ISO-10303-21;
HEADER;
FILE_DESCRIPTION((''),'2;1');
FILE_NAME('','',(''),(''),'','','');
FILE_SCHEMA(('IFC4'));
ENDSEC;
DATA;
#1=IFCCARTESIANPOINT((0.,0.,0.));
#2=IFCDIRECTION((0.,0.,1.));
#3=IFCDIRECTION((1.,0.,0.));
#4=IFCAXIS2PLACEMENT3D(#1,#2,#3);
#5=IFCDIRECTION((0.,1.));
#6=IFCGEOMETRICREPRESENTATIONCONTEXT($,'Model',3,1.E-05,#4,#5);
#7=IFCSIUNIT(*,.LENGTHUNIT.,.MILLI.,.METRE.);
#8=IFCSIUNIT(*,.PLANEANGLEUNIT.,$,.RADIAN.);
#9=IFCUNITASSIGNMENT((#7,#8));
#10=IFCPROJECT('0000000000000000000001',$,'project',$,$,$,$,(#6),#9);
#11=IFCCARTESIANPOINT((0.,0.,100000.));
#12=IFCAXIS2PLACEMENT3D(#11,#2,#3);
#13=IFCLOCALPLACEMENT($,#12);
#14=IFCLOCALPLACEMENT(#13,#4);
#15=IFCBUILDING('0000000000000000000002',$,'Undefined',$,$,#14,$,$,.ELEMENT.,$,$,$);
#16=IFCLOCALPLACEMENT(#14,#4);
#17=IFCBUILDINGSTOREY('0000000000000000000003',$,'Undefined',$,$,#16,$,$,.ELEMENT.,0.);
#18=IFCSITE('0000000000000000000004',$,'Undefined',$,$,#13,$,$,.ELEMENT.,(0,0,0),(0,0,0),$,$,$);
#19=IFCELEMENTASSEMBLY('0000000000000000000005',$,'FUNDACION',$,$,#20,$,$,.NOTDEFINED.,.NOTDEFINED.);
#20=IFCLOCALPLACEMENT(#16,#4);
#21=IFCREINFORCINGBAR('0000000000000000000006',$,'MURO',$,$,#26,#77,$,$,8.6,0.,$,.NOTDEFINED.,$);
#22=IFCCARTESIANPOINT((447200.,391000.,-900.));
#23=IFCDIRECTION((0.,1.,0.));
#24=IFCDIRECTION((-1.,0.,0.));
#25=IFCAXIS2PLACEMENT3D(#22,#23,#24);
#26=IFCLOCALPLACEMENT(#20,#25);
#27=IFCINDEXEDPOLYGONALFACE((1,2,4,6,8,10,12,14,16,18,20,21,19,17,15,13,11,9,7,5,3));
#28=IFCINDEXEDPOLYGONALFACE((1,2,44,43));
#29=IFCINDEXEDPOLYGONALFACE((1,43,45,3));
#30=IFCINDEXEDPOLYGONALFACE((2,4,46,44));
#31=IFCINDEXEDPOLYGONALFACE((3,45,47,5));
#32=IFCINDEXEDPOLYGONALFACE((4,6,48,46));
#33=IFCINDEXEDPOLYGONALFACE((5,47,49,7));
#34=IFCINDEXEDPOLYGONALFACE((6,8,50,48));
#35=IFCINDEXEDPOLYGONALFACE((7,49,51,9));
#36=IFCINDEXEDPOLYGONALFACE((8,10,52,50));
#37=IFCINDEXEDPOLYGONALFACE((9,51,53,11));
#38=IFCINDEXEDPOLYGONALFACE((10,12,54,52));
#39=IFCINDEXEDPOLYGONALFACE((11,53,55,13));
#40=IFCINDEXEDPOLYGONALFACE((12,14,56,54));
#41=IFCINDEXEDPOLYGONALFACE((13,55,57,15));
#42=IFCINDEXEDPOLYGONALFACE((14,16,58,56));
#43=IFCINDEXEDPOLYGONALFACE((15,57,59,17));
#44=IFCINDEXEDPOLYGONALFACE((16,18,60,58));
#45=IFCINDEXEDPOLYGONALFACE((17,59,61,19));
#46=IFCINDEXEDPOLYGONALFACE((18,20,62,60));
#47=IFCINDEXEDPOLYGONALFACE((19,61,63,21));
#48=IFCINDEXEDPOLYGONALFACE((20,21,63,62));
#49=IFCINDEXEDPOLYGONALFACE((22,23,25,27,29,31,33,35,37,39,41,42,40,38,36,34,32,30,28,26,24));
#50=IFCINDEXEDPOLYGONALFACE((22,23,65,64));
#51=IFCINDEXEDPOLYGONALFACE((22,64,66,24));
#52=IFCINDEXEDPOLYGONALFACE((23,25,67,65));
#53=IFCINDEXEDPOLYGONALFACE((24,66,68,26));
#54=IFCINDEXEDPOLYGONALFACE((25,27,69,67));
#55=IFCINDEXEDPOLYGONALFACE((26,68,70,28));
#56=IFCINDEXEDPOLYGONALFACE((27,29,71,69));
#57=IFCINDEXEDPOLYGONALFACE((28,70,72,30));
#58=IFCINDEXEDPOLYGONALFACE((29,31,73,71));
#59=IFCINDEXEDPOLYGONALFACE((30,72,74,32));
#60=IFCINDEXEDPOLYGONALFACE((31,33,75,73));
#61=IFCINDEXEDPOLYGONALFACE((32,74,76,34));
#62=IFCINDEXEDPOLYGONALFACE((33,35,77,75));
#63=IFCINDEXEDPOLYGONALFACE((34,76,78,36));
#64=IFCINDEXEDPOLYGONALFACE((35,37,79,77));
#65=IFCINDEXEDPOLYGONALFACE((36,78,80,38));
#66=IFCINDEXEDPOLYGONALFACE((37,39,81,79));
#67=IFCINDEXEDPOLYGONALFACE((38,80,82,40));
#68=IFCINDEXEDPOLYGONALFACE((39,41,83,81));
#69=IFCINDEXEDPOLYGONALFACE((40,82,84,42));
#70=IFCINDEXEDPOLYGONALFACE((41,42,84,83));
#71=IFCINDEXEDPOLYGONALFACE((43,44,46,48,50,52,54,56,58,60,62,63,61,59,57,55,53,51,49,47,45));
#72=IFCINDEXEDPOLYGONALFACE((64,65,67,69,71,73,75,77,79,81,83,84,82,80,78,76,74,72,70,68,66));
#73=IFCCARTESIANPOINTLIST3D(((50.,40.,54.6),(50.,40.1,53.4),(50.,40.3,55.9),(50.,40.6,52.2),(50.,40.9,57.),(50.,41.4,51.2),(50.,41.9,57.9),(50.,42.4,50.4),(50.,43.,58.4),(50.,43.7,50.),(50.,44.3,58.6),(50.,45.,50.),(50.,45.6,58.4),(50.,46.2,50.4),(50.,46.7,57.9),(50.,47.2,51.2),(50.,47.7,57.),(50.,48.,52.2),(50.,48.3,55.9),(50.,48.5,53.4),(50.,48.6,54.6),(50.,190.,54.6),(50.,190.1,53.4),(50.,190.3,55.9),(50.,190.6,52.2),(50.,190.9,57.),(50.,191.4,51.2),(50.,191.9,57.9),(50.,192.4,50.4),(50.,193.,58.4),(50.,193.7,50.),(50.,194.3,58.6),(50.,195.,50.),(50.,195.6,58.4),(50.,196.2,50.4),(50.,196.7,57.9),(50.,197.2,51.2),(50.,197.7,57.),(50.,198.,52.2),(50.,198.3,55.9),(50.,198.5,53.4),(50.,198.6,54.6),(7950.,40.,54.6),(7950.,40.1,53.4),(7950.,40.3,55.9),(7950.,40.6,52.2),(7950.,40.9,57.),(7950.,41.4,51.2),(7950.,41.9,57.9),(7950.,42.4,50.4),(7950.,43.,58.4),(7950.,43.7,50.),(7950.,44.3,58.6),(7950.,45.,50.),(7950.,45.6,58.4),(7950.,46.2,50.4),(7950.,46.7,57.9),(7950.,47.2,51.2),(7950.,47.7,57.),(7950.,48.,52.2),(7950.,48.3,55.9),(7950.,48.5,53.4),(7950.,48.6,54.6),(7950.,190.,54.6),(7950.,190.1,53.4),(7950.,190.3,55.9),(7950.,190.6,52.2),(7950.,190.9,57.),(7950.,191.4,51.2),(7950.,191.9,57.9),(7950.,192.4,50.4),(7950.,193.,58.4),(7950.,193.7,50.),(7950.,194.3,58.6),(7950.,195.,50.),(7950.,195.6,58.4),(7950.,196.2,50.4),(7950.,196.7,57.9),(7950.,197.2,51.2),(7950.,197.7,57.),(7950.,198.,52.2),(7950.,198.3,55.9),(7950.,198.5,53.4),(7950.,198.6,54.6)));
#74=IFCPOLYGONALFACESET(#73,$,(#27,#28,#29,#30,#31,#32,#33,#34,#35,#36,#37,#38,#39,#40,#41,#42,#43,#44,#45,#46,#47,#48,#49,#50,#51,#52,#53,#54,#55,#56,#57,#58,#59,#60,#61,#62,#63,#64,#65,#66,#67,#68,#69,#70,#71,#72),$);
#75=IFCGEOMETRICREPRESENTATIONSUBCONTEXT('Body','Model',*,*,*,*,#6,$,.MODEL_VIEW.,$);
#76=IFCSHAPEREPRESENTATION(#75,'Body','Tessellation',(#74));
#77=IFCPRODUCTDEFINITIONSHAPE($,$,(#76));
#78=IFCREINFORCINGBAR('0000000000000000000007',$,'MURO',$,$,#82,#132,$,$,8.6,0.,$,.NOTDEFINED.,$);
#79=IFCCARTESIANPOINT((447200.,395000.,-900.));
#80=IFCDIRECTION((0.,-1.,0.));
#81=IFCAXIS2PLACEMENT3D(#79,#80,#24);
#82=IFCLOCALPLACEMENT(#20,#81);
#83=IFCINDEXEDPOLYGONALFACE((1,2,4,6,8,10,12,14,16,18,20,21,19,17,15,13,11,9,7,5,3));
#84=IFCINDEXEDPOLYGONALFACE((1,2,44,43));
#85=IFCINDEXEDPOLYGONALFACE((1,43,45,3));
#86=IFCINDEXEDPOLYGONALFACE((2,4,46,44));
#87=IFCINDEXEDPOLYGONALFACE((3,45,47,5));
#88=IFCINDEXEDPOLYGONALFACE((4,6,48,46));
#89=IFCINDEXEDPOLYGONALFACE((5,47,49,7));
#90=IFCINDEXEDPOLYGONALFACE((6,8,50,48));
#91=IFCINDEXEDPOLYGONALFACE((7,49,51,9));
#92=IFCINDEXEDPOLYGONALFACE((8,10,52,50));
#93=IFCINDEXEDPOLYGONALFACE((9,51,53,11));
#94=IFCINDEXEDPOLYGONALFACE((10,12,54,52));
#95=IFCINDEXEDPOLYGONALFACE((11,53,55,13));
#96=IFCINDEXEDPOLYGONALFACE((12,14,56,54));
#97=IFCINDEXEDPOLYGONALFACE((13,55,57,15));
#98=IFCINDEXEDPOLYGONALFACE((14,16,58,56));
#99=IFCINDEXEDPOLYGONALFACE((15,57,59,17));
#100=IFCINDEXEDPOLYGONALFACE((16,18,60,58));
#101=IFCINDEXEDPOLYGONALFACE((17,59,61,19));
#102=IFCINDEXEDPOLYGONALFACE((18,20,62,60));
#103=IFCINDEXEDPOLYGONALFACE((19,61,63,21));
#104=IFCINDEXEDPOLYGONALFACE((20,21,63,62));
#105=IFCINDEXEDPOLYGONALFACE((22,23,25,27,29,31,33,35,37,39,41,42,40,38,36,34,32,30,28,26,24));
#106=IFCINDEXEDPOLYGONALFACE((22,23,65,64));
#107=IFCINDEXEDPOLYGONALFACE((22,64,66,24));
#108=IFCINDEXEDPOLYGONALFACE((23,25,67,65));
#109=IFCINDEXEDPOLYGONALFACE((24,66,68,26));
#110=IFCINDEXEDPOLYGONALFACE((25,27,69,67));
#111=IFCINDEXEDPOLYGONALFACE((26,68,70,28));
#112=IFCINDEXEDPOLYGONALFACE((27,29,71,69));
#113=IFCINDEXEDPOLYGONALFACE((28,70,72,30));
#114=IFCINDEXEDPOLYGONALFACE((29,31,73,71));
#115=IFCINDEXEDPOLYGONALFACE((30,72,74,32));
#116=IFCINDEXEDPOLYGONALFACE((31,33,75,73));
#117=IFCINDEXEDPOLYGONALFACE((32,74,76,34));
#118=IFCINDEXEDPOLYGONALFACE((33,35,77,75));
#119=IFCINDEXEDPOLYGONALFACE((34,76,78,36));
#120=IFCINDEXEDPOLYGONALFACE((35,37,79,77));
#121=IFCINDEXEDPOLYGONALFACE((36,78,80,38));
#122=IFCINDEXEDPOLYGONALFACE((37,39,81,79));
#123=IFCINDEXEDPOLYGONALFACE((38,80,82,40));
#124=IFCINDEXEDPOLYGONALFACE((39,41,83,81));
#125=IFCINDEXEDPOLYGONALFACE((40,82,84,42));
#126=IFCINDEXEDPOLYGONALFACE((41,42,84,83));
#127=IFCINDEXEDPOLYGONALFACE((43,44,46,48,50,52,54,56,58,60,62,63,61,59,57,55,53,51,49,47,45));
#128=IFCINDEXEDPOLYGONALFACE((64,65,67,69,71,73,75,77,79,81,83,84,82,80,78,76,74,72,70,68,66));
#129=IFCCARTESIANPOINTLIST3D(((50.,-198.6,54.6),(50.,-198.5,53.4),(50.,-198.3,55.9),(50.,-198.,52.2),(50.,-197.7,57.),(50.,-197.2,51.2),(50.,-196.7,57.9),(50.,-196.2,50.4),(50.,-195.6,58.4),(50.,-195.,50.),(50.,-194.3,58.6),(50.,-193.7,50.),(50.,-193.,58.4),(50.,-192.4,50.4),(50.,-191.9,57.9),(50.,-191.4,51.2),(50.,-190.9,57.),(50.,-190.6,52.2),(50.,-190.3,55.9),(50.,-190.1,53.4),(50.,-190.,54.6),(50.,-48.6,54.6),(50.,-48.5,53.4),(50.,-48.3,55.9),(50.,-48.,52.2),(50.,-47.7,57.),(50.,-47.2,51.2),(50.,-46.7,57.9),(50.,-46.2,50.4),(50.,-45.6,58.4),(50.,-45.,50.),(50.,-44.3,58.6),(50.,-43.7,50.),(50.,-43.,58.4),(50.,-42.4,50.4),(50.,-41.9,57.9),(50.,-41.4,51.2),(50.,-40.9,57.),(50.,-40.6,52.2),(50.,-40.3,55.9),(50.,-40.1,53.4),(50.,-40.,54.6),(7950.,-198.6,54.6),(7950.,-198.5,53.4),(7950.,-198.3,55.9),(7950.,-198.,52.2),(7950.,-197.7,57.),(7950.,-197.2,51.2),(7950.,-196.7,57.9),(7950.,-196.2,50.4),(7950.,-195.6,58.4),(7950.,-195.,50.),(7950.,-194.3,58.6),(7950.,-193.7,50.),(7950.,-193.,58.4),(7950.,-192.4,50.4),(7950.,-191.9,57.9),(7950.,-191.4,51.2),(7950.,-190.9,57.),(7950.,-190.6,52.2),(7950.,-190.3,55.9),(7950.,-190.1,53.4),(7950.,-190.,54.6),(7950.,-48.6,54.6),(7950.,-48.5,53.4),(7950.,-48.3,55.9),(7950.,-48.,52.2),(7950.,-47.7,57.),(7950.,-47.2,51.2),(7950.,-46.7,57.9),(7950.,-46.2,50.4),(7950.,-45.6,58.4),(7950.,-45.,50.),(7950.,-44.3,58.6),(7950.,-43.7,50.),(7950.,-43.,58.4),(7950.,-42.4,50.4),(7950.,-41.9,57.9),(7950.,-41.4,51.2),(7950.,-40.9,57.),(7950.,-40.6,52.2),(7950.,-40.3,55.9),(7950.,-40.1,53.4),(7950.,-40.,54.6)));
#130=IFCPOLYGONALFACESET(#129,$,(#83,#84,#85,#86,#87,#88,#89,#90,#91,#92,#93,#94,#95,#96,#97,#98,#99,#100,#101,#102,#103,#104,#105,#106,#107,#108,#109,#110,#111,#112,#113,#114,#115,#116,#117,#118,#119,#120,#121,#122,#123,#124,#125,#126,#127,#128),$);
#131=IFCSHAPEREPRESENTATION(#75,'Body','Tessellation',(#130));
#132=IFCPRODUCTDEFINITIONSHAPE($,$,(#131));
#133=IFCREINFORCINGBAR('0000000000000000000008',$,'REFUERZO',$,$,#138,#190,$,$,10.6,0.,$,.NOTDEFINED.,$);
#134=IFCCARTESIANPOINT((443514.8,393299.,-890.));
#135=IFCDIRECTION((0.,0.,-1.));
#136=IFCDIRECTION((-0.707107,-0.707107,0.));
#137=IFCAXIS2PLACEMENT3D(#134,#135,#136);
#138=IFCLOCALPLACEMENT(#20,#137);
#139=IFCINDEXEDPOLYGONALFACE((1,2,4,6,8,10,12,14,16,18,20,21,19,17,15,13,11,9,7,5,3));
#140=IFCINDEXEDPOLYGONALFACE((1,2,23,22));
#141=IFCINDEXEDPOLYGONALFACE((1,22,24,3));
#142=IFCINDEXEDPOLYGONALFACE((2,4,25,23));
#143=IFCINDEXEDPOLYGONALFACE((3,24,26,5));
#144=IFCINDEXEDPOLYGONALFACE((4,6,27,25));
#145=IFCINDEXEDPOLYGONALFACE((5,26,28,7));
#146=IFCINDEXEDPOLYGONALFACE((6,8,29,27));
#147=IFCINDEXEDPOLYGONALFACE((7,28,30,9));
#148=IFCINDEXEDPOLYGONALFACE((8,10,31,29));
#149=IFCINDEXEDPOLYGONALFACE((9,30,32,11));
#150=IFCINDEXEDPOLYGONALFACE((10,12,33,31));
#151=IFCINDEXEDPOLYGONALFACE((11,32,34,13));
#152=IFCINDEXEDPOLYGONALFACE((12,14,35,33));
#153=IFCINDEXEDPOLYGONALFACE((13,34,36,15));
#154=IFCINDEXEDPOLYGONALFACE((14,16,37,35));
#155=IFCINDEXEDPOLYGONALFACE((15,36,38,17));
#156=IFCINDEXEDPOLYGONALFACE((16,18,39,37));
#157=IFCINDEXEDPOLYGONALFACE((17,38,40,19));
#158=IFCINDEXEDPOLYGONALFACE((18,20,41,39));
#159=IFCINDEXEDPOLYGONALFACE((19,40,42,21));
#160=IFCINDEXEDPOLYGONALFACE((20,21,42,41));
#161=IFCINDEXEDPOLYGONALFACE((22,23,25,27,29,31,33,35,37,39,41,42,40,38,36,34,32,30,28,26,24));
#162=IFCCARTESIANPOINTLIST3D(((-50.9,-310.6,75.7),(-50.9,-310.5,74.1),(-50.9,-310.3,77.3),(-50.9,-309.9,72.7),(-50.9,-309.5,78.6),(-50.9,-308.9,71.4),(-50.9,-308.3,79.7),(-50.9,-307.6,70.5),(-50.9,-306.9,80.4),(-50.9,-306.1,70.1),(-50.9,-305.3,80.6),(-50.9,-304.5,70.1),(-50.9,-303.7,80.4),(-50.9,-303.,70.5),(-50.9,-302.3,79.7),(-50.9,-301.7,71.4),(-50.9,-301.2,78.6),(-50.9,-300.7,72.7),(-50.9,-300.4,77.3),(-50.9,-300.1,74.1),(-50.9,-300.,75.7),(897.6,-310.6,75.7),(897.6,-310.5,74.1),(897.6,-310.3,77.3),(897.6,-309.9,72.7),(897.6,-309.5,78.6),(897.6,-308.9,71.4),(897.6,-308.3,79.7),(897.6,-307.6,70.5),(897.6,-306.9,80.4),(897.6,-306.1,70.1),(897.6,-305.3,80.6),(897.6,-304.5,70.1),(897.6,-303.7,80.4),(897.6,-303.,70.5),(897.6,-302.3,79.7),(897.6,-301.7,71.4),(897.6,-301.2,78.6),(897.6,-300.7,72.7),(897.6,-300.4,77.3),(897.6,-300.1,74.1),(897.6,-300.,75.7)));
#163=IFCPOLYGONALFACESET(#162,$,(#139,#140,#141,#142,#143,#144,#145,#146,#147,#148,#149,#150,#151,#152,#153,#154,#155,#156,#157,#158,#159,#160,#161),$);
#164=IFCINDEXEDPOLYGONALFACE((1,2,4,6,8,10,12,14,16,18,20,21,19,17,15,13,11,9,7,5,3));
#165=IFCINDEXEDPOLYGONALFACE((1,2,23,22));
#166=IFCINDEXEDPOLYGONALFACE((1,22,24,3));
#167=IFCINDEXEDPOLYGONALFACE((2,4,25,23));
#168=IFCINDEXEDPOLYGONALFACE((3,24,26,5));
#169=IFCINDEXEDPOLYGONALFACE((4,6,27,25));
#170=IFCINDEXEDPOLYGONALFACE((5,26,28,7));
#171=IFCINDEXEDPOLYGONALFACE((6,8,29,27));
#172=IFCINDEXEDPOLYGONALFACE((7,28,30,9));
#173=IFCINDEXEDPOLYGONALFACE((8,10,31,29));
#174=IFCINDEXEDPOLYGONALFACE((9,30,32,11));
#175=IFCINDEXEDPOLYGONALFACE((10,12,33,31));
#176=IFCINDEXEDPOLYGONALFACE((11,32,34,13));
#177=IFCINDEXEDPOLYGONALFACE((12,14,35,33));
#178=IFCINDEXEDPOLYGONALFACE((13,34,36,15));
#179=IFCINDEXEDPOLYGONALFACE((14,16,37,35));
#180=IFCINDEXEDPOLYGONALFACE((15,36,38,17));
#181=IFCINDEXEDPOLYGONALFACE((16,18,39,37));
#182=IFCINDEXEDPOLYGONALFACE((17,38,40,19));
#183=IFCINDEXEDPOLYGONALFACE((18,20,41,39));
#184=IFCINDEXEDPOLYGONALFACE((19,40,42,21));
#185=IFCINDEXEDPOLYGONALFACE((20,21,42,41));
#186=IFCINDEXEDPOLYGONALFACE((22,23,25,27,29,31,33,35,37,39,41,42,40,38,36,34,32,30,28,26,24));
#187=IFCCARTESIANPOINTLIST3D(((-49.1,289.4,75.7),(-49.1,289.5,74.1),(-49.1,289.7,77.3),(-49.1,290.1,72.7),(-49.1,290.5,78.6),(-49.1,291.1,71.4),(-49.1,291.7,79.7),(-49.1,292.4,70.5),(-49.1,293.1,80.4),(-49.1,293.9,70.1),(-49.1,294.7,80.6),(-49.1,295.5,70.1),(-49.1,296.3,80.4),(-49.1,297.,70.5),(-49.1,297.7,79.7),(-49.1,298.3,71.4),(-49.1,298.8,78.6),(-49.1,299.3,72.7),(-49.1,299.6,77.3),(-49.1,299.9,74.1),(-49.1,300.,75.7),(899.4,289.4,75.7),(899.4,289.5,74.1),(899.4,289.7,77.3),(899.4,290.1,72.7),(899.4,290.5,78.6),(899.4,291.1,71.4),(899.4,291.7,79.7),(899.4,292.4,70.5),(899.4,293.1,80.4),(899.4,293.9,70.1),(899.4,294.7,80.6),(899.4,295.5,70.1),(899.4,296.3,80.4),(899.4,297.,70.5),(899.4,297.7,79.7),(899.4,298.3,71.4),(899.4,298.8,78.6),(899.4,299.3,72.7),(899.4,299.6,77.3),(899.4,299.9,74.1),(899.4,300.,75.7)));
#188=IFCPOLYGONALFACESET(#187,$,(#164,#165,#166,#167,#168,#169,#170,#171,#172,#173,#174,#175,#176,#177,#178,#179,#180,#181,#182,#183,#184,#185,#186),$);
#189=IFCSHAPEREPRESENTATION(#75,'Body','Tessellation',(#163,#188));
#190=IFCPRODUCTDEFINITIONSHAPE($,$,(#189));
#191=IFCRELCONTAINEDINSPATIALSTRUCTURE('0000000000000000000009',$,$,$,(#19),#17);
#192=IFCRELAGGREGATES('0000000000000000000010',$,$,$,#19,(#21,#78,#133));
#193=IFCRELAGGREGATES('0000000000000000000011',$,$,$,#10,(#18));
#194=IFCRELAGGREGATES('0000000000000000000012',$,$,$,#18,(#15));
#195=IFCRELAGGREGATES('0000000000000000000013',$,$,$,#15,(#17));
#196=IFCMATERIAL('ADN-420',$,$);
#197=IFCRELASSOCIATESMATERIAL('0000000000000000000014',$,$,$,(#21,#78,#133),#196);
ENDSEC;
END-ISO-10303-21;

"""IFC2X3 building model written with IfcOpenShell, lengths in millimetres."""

from ifc_helpers import new_model, entity, si_unit, direction, frame, origin_with_axes, place, context, subcontext, project, spatial, source, transform, mapped, material, element, aggregate, save


model = new_model("IFC2X3")

# Units and contexts
model_context = context("Model", 3, precision=1e-05, world=origin_with_axes(), true_north=direction((0.0, 1.0)))
body_context = subcontext(model_context, "Body", "Model", "MODEL_VIEW")
ifc_project = project(units=[si_unit("LENGTHUNIT", "METRE", prefix="MILLI"), si_unit("PLANEANGLEUNIT", "RADIAN")], contexts=[model_context])

# Site, building, storey
site_placement = place(None, frame((0.0, 0.0, 100000.0), z_axis=(0.0, 0.0, 1.0), x_axis=(1.0, 0.0, 0.0)))
site = spatial("IfcSite", under=ifc_project, at=site_placement, Name="Undefined", CompositionType="ELEMENT", RefLatitude=(0, 0, 0), RefLongitude=(0, 0, 0))
building_placement = place(site_placement, origin_with_axes())
building = spatial("IfcBuilding", under=site, at=building_placement, Name="Undefined", CompositionType="ELEMENT")
storey_placement = place(building_placement, origin_with_axes())
storey = spatial("IfcBuildingStorey", under=building, at=storey_placement, Name="Undefined", CompositionType="ELEMENT", Elevation=0.0)

# Element assembly, reinforcing bars
assembly_1_placement = place(storey_placement, origin_with_axes())
assembly_1 = element("IfcElementAssembly", 1, at=assembly_1_placement, inside=storey, Name="FUNDACION", AssemblyPlace="NOTDEFINED", PredefinedType="NOTDEFINED")
ifc_material_1 = material(Name="ADN-420")
shared_shape_1 = source(origin_with_axes(), body_context, "Body", "AdvancedSweptSolid", [
    entity("IfcSweptDiskSolid", entity("IfcTrimmedCurve", entity("IfcLine", entity("IfcCartesianPoint", [0.0, 0.0, 0.0]), entity("IfcVector", entity("IfcDirection", [1.0, 0.0, 0.0]), 1.0)), [entity("IfcParameterValue", 0.0)], [entity("IfcParameterValue", 7900.0)], True, "PARAMETER"), 4.3, None, 0.0, 7900.0),
])
shared_shape_2 = source(origin_with_axes(), body_context, "Body", "AdvancedSweptSolid", [
    entity("IfcSweptDiskSolid", entity("IfcTrimmedCurve", entity("IfcLine", entity("IfcCartesianPoint", [0.0, 0.0, 0.0]), entity("IfcVector", entity("IfcDirection", [1.0, 0.0, 0.0]), 1.0)), [entity("IfcParameterValue", 0.0)], [entity("IfcParameterValue", 7900.0)], True, "PARAMETER"), 4.3, None, 0.0, 7900.0),
])
reinforcing_bar_1_placement = place(assembly_1_placement, frame((447200.0, 391000.0, -900.0), z_axis=(0.0, 1.0, 0.0), x_axis=(-1.0, 0.0, 0.0)))
reinforcing_bar_1 = element("IfcReinforcingBar", 2, at=reinforcing_bar_1_placement, material=ifc_material_1, Name="MURO", BarRole="NOTDEFINED", CrossSectionArea=0.0, NominalDiameter=8.6, context=body_context, shape_type="MappedRepresentation", body=[
    mapped(shared_shape_1, transform((50.0, 44.3, 54.3))),
    mapped(shared_shape_2, transform((50.0, 194.3, 54.3))),
])
shared_shape_3 = source(origin_with_axes(), body_context, "Body", "AdvancedSweptSolid", [
    entity("IfcSweptDiskSolid", entity("IfcTrimmedCurve", entity("IfcLine", entity("IfcCartesianPoint", [0.0, 0.0, 0.0]), entity("IfcVector", entity("IfcDirection", [1.0, 0.0, 0.0]), 1.0)), [entity("IfcParameterValue", 0.0)], [entity("IfcParameterValue", 7900.0)], True, "PARAMETER"), 4.3, None, 0.0, 7900.0),
])
shared_shape_4 = source(origin_with_axes(), body_context, "Body", "AdvancedSweptSolid", [
    entity("IfcSweptDiskSolid", entity("IfcTrimmedCurve", entity("IfcLine", entity("IfcCartesianPoint", [0.0, 0.0, 0.0]), entity("IfcVector", entity("IfcDirection", [1.0, 0.0, 0.0]), 1.0)), [entity("IfcParameterValue", 0.0)], [entity("IfcParameterValue", 7900.0)], True, "PARAMETER"), 4.3, None, 0.0, 7900.0),
])
reinforcing_bar_2_placement = place(assembly_1_placement, frame((447200.0, 395000.0, -900.0), z_axis=(0.0, -1.0, 0.0), x_axis=(-1.0, 0.0, 0.0)))
reinforcing_bar_2 = element("IfcReinforcingBar", 3, at=reinforcing_bar_2_placement, material=ifc_material_1, Name="MURO", BarRole="NOTDEFINED", CrossSectionArea=0.0, NominalDiameter=8.6, context=body_context, shape_type="MappedRepresentation", body=[
    mapped(shared_shape_3, transform((50.0, -194.3, 54.3))),
    mapped(shared_shape_4, transform((50.0, -44.3, 54.3))),
])
shared_shape_5 = source(origin_with_axes(), body_context, "Body", "AdvancedSweptSolid", [
    entity("IfcSweptDiskSolid", entity("IfcTrimmedCurve", entity("IfcLine", entity("IfcCartesianPoint", [0.0, 0.0, 0.0]), entity("IfcVector", entity("IfcDirection", [1.0, 0.0, 0.0]), 1.0)), [entity("IfcParameterValue", 0.0)], [entity("IfcParameterValue", 948.528137)], True, "PARAMETER"), 5.3, None, 0.0, 948.5),
])
shared_shape_6 = source(origin_with_axes(), body_context, "Body", "AdvancedSweptSolid", [
    entity("IfcSweptDiskSolid", entity("IfcTrimmedCurve", entity("IfcLine", entity("IfcCartesianPoint", [0.0, 0.0, 0.0]), entity("IfcVector", entity("IfcDirection", [1.0, 0.0, 0.0]), 1.0)), [entity("IfcParameterValue", 0.0)], [entity("IfcParameterValue", 948.528137)], True, "PARAMETER"), 5.3, None, 0.0, 948.5),
])
reinforcing_bar_3_placement = place(assembly_1_placement, frame((443514.8, 393299.0, -890.0), z_axis=(0.0, 0.0, -1.0), x_axis=(-0.707107, -0.707107, 0.0)))
reinforcing_bar_3 = element("IfcReinforcingBar", 4, at=reinforcing_bar_3_placement, material=ifc_material_1, Name="REFUERZO", BarRole="NOTDEFINED", CrossSectionArea=0.0, NominalDiameter=10.6, context=body_context, shape_type="MappedRepresentation", body=[
    mapped(shared_shape_5, transform((-50.9, -305.3, 75.3))),
    mapped(shared_shape_6, transform((-49.1, 294.7, 75.3))),
])
aggregate(assembly_1, [reinforcing_bar_1, reinforcing_bar_2, reinforcing_bar_3])

save(model, "model.ifc")
